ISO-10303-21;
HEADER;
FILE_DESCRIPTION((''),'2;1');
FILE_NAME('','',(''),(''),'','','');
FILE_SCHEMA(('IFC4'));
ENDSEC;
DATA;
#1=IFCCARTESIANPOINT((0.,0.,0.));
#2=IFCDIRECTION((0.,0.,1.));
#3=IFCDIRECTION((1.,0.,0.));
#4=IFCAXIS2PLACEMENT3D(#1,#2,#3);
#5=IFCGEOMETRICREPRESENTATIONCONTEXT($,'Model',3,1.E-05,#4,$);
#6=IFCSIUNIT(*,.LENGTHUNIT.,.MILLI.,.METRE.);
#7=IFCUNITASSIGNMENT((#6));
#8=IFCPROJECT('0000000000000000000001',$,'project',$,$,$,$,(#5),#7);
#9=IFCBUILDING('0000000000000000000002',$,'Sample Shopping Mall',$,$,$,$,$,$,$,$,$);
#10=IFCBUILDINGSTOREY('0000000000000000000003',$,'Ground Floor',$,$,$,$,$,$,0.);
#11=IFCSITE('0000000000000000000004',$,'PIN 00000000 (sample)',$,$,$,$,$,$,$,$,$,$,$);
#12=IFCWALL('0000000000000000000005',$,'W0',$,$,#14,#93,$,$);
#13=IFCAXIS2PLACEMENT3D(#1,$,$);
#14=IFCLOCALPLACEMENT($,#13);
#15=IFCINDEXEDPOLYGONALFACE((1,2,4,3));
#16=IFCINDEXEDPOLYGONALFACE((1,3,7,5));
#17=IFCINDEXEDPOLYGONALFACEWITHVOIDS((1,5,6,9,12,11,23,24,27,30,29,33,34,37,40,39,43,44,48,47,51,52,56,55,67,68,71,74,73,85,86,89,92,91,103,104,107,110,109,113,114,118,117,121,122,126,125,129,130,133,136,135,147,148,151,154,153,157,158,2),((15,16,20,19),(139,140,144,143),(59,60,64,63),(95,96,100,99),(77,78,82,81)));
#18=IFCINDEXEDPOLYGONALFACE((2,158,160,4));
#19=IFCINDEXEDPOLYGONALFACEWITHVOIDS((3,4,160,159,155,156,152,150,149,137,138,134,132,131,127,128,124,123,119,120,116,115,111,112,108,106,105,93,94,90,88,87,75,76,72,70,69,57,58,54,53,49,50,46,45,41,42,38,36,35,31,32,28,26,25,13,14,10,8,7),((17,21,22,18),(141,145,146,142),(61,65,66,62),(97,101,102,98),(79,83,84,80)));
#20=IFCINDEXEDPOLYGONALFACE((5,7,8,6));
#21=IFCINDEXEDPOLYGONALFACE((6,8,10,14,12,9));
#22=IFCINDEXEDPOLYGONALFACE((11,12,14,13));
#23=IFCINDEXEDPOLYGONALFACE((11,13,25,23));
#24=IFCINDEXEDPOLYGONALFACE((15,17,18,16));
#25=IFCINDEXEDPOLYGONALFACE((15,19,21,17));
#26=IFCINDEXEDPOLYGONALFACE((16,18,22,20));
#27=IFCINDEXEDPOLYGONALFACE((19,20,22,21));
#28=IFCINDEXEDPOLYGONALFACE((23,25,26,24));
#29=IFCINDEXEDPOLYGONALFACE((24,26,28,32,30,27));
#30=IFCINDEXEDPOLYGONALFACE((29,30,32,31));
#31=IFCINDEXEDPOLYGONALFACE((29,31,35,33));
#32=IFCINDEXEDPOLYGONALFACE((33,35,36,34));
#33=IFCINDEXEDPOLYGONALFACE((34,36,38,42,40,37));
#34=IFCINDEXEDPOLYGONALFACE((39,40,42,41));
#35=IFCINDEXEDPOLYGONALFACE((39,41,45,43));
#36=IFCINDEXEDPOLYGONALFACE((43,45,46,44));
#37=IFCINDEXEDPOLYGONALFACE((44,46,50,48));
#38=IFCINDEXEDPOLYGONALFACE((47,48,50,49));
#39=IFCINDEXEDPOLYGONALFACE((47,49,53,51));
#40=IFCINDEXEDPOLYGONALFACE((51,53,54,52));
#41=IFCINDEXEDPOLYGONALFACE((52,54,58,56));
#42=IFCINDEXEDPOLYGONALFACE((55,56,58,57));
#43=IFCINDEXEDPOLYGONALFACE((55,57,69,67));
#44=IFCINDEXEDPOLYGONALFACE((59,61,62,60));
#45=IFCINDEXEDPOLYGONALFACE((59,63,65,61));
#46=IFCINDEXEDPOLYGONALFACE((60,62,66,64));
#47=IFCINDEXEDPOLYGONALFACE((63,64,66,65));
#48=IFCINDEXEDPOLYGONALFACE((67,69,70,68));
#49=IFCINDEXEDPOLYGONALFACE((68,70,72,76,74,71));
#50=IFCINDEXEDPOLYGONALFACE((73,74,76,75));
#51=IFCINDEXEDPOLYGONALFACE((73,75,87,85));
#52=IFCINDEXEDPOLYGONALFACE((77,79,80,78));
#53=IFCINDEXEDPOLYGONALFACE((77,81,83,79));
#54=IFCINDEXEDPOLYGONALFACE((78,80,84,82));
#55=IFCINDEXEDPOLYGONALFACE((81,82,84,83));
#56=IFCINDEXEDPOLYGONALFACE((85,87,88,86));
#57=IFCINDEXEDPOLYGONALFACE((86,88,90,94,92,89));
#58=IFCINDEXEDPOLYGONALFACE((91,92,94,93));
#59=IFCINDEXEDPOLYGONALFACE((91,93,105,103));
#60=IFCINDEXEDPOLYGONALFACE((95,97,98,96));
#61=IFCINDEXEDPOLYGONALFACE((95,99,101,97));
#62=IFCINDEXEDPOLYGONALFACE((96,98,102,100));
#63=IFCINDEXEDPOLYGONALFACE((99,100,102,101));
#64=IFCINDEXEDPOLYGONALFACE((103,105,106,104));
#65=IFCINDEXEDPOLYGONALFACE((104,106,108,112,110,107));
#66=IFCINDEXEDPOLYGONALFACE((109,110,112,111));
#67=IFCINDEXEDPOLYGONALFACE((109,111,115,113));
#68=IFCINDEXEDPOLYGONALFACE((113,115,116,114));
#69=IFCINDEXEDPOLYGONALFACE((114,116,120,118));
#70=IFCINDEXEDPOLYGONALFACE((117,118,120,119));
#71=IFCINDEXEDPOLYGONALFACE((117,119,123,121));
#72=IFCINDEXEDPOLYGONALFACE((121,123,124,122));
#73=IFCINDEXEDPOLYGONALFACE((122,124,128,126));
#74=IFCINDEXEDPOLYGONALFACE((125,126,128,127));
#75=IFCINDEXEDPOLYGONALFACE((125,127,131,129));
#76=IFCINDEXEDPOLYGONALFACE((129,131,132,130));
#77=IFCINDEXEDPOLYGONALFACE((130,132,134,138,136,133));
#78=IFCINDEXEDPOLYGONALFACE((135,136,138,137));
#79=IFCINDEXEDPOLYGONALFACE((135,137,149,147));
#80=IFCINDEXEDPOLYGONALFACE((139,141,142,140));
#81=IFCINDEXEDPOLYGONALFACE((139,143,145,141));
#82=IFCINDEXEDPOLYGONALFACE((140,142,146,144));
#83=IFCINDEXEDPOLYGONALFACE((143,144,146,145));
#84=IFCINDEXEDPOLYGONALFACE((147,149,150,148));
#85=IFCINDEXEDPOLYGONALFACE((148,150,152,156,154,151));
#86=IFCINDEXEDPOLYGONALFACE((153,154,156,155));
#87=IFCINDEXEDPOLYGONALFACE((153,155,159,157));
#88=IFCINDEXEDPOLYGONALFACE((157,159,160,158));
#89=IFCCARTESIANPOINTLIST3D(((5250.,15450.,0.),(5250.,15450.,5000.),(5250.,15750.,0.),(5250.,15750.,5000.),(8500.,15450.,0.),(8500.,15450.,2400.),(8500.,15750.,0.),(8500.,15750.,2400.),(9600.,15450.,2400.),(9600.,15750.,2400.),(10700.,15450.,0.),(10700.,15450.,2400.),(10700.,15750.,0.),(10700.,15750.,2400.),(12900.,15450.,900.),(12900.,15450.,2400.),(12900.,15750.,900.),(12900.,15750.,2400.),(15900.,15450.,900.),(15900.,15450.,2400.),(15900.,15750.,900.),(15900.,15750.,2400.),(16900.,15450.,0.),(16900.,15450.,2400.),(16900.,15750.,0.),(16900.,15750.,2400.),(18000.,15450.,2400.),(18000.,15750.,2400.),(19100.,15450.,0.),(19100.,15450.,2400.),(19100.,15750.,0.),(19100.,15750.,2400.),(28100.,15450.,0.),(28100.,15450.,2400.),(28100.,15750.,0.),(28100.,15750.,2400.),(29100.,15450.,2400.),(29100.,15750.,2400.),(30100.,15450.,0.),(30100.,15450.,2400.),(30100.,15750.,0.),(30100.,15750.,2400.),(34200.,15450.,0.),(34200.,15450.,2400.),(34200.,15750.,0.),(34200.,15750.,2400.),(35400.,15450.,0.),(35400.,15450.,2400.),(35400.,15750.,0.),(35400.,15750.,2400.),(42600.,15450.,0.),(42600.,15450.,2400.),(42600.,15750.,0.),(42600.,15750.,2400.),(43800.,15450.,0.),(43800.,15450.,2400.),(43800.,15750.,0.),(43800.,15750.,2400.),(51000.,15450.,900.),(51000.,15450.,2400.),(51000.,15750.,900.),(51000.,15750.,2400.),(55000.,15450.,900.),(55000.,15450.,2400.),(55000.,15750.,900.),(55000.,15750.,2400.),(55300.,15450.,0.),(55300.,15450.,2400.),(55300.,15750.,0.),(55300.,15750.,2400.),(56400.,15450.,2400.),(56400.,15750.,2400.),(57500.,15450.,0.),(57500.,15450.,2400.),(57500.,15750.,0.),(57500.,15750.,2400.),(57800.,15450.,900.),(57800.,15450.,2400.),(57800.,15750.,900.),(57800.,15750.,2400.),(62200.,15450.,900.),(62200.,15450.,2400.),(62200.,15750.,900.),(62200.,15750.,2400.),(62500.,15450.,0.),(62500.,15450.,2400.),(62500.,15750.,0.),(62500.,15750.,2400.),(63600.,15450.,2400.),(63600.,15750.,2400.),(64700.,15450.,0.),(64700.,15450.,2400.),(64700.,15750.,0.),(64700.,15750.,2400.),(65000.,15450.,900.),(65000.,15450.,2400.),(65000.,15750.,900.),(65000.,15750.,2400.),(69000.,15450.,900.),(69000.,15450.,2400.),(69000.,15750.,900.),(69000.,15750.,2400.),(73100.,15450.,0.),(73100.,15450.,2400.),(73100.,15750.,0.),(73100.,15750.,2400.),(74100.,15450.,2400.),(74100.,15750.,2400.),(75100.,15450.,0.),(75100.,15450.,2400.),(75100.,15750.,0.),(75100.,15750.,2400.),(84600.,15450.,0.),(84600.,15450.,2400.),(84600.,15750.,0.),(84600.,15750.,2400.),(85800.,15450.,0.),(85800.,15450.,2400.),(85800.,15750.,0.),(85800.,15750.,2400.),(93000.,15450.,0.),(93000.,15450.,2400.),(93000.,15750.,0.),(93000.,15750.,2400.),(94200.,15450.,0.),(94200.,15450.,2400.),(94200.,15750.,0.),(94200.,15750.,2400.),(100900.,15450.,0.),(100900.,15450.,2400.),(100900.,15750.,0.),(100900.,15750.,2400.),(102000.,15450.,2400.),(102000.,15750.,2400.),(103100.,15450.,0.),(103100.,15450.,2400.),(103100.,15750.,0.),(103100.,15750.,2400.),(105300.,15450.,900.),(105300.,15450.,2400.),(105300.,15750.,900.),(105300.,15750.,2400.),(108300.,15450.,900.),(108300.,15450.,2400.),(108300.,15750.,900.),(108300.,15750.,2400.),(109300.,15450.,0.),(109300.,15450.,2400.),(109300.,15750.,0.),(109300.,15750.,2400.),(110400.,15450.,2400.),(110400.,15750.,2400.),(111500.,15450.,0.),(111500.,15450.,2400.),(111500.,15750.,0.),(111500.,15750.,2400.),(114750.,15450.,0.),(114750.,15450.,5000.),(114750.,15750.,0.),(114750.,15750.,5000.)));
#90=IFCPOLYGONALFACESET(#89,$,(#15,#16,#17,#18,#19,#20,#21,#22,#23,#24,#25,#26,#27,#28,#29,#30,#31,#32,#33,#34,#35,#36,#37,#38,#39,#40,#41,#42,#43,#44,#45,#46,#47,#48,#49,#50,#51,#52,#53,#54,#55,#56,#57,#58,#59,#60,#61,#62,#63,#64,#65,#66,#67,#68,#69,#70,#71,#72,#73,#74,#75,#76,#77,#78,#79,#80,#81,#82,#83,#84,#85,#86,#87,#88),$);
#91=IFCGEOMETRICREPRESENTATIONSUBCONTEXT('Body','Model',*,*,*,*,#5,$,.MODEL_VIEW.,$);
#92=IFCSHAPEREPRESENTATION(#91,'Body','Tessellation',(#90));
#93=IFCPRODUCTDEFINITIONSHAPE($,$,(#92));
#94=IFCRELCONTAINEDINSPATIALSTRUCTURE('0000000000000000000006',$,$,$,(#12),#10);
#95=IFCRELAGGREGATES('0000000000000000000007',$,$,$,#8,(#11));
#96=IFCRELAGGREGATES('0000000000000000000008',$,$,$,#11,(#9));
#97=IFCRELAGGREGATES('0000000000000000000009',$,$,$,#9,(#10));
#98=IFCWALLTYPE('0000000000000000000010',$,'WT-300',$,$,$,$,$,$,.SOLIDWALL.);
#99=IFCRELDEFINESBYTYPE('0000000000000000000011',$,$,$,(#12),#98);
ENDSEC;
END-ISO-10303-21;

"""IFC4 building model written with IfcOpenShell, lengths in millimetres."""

from ifc_helpers import new_model, si_unit, frame, origin_with_axes, place, context, subcontext, project, spatial, indexed_curve, outline, extrude, type_object, element, save


model = new_model("IFC4")

# Units and contexts
model_context = context("Model", 3, precision=1e-05, world=origin_with_axes())
body_context = subcontext(model_context, "Body", "Model", "MODEL_VIEW")
ifc_project = project(units=[si_unit("LENGTHUNIT", "METRE", prefix="MILLI")], contexts=[model_context])

# Site, building, storey
site = spatial("IfcSite", under=ifc_project, Name="PIN 00000000 (sample)")
building = spatial("IfcBuilding", under=site, Name="Sample Shopping Mall")
storey = spatial("IfcBuildingStorey", under=building, Name="Ground Floor", Elevation=0.0)

# Wall, openings
wall_type = type_object("IfcWallType", Name="WT-300", PredefinedType="SOLIDWALL")
wall_placement = place(None, frame((5250.0, 15450.0, 0.0), z_axis=(0.0, 0.0, 1.0), x_axis=(1.0, 0.0, 0.0)))
wall = element("IfcWall", 1, at=wall_placement, inside=storey, type_object=wall_type, Name="W0", context=body_context, shape_type="SweptSolid", body=[
    extrude(outline(indexed_curve([(0.0, 0.0), (0.0, 300.0), (109500.0, 300.0), (109500.0, 0.0), (0.0, 0.0)], self_intersect=False)), origin_with_axes(), (0.0, 0.0, 1.0), 5000.0),
])
opening_1_placement = place(wall_placement, frame((50050.0, -100.0, 0.0), z_axis=(0.0, 0.0, 1.0), x_axis=(1.0, 0.0, 0.0)))
element("IfcOpeningElement", 2, at=opening_1_placement, cuts=wall, context=body_context, shape_type="SweptSolid", body=[
    extrude(outline(indexed_curve([(0.0, 0.0), (0.0, 500.0), (1100.0, 500.0), (1100.0, 0.0), (0.0, 0.0)], self_intersect=False)), origin_with_axes(), (0.0, 0.0, 1.0), 2400.0),
])
opening_2_placement = place(wall_placement, frame((51150.0, -100.0, 0.0), z_axis=(0.0, 0.0, 1.0), x_axis=(1.0, 0.0, 0.0)))
element("IfcOpeningElement", 3, at=opening_2_placement, cuts=wall, context=body_context, shape_type="SweptSolid", body=[
    extrude(outline(indexed_curve([(0.0, 0.0), (0.0, 500.0), (1100.0, 500.0), (1100.0, 0.0), (0.0, 0.0)], self_intersect=False)), origin_with_axes(), (0.0, 0.0, 1.0), 2400.0),
])
opening_3_placement = place(wall_placement, frame((57250.0, -100.0, 0.0), z_axis=(0.0, 0.0, 1.0), x_axis=(1.0, 0.0, 0.0)))
element("IfcOpeningElement", 4, at=opening_3_placement, cuts=wall, context=body_context, shape_type="SweptSolid", body=[
    extrude(outline(indexed_curve([(0.0, 0.0), (0.0, 500.0), (1100.0, 500.0), (1100.0, 0.0), (0.0, 0.0)], self_intersect=False)), origin_with_axes(), (0.0, 0.0, 1.0), 2400.0),
])
opening_4_placement = place(wall_placement, frame((58350.0, -100.0, 0.0), z_axis=(0.0, 0.0, 1.0), x_axis=(1.0, 0.0, 0.0)))
element("IfcOpeningElement", 5, at=opening_4_placement, cuts=wall, context=body_context, shape_type="SweptSolid", body=[
    extrude(outline(indexed_curve([(0.0, 0.0), (0.0, 500.0), (1100.0, 500.0), (1100.0, 0.0), (0.0, 0.0)], self_intersect=False)), origin_with_axes(), (0.0, 0.0, 1.0), 2400.0),
])
opening_5_placement = place(wall_placement, frame((3250.0, -100.0, 0.0), z_axis=(0.0, 0.0, 1.0), x_axis=(1.0, 0.0, 0.0)))
element("IfcOpeningElement", 6, at=opening_5_placement, cuts=wall, context=body_context, shape_type="SweptSolid", body=[
    extrude(outline(indexed_curve([(0.0, 0.0), (0.0, 500.0), (1100.0, 500.0), (1100.0, 0.0), (0.0, 0.0)], self_intersect=False)), origin_with_axes(), (0.0, 0.0, 1.0), 2400.0),
])
opening_6_placement = place(wall_placement, frame((4350.0, -100.0, 0.0), z_axis=(0.0, 0.0, 1.0), x_axis=(1.0, 0.0, 0.0)))
element("IfcOpeningElement", 7, at=opening_6_placement, cuts=wall, context=body_context, shape_type="SweptSolid", body=[
    extrude(outline(indexed_curve([(0.0, 0.0), (0.0, 500.0), (1100.0, 500.0), (1100.0, 0.0), (0.0, 0.0)], self_intersect=False)), origin_with_axes(), (0.0, 0.0, 1.0), 2400.0),
])
opening_7_placement = place(wall_placement, frame((11650.0, -100.0, 0.0), z_axis=(0.0, 0.0, 1.0), x_axis=(1.0, 0.0, 0.0)))
element("IfcOpeningElement", 8, at=opening_7_placement, cuts=wall, context=body_context, shape_type="SweptSolid", body=[
    extrude(outline(indexed_curve([(0.0, 0.0), (0.0, 500.0), (1100.0, 500.0), (1100.0, 0.0), (0.0, 0.0)], self_intersect=False)), origin_with_axes(), (0.0, 0.0, 1.0), 2400.0),
])
opening_8_placement = place(wall_placement, frame((12750.0, -100.0, 0.0), z_axis=(0.0, 0.0, 1.0), x_axis=(1.0, 0.0, 0.0)))
element("IfcOpeningElement", 9, at=opening_8_placement, cuts=wall, context=body_context, shape_type="SweptSolid", body=[
    extrude(outline(indexed_curve([(0.0, 0.0), (0.0, 500.0), (1100.0, 500.0), (1100.0, 0.0), (0.0, 0.0)], self_intersect=False)), origin_with_axes(), (0.0, 0.0, 1.0), 2400.0),
])
opening_9_placement = place(wall_placement, frame((95650.0, -100.0, 0.0), z_axis=(0.0, 0.0, 1.0), x_axis=(1.0, 0.0, 0.0)))
element("IfcOpeningElement", 10, at=opening_9_placement, cuts=wall, context=body_context, shape_type="SweptSolid", body=[
    extrude(outline(indexed_curve([(0.0, 0.0), (0.0, 500.0), (1100.0, 500.0), (1100.0, 0.0), (0.0, 0.0)], self_intersect=False)), origin_with_axes(), (0.0, 0.0, 1.0), 2400.0),
])
opening_10_placement = place(wall_placement, frame((96750.0, -100.0, 0.0), z_axis=(0.0, 0.0, 1.0), x_axis=(1.0, 0.0, 0.0)))
element("IfcOpeningElement", 11, at=opening_10_placement, cuts=wall, context=body_context, shape_type="SweptSolid", body=[
    extrude(outline(indexed_curve([(0.0, 0.0), (0.0, 500.0), (1100.0, 500.0), (1100.0, 0.0), (0.0, 0.0)], self_intersect=False)), origin_with_axes(), (0.0, 0.0, 1.0), 2400.0),
])
opening_11_placement = place(wall_placement, frame((104050.0, -100.0, 0.0), z_axis=(0.0, 0.0, 1.0), x_axis=(1.0, 0.0, 0.0)))
element("IfcOpeningElement", 12, at=opening_11_placement, cuts=wall, context=body_context, shape_type="SweptSolid", body=[
    extrude(outline(indexed_curve([(0.0, 0.0), (0.0, 500.0), (1100.0, 500.0), (1100.0, 0.0), (0.0, 0.0)], self_intersect=False)), origin_with_axes(), (0.0, 0.0, 1.0), 2400.0),
])
opening_12_placement = place(wall_placement, frame((105150.0, -100.0, 0.0), z_axis=(0.0, 0.0, 1.0), x_axis=(1.0, 0.0, 0.0)))
element("IfcOpeningElement", 13, at=opening_12_placement, cuts=wall, context=body_context, shape_type="SweptSolid", body=[
    extrude(outline(indexed_curve([(0.0, 0.0), (0.0, 500.0), (1100.0, 500.0), (1100.0, 0.0), (0.0, 0.0)], self_intersect=False)), origin_with_axes(), (0.0, 0.0, 1.0), 2400.0),
])
opening_13_placement = place(wall_placement, frame((28950.0, -100.0, 0.0), z_axis=(0.0, 0.0, 1.0), x_axis=(1.0, 0.0, 0.0)))
element("IfcOpeningElement", 14, at=opening_13_placement, cuts=wall, context=body_context, shape_type="SweptSolid", body=[
    extrude(outline(indexed_curve([(0.0, 0.0), (0.0, 500.0), (1200.0, 500.0), (1200.0, 0.0), (0.0, 0.0)], self_intersect=False)), origin_with_axes(), (0.0, 0.0, 1.0), 2400.0),
])
opening_14_placement = place(wall_placement, frame((37350.0, -100.0, 0.0), z_axis=(0.0, 0.0, 1.0), x_axis=(1.0, 0.0, 0.0)))
element("IfcOpeningElement", 15, at=opening_14_placement, cuts=wall, context=body_context, shape_type="SweptSolid", body=[
    extrude(outline(indexed_curve([(0.0, 0.0), (0.0, 500.0), (1200.0, 500.0), (1200.0, 0.0), (0.0, 0.0)], self_intersect=False)), origin_with_axes(), (0.0, 0.0, 1.0), 2400.0),
])
opening_15_placement = place(wall_placement, frame((79350.0, -100.0, 0.0), z_axis=(0.0, 0.0, 1.0), x_axis=(1.0, 0.0, 0.0)))
element("IfcOpeningElement", 16, at=opening_15_placement, cuts=wall, context=body_context, shape_type="SweptSolid", body=[
    extrude(outline(indexed_curve([(0.0, 0.0), (0.0, 500.0), (1200.0, 500.0), (1200.0, 0.0), (0.0, 0.0)], self_intersect=False)), origin_with_axes(), (0.0, 0.0, 1.0), 2400.0),
])
opening_16_placement = place(wall_placement, frame((87750.0, -100.0, 0.0), z_axis=(0.0, 0.0, 1.0), x_axis=(1.0, 0.0, 0.0)))
element("IfcOpeningElement", 17, at=opening_16_placement, cuts=wall, context=body_context, shape_type="SweptSolid", body=[
    extrude(outline(indexed_curve([(0.0, 0.0), (0.0, 500.0), (1200.0, 500.0), (1200.0, 0.0), (0.0, 0.0)], self_intersect=False)), origin_with_axes(), (0.0, 0.0, 1.0), 2400.0),
])
opening_17_placement = place(wall_placement, frame((22850.0, -100.0, 0.0), z_axis=(0.0, 0.0, 1.0), x_axis=(1.0, 0.0, 0.0)))
element("IfcOpeningElement", 18, at=opening_17_placement, cuts=wall, context=body_context, shape_type="SweptSolid", body=[
    extrude(outline(indexed_curve([(0.0, 0.0), (0.0, 500.0), (1000.0, 500.0), (1000.0, 0.0), (0.0, 0.0)], self_intersect=False)), origin_with_axes(), (0.0, 0.0, 1.0), 2400.0),
])
opening_18_placement = place(wall_placement, frame((23850.0, -100.0, 0.0), z_axis=(0.0, 0.0, 1.0), x_axis=(1.0, 0.0, 0.0)))
element("IfcOpeningElement", 19, at=opening_18_placement, cuts=wall, context=body_context, shape_type="SweptSolid", body=[
    extrude(outline(indexed_curve([(0.0, 0.0), (0.0, 500.0), (1000.0, 500.0), (1000.0, 0.0), (0.0, 0.0)], self_intersect=False)), origin_with_axes(), (0.0, 0.0, 1.0), 2400.0),
])
opening_19_placement = place(wall_placement, frame((67850.0, -100.0, 0.0), z_axis=(0.0, 0.0, 1.0), x_axis=(1.0, 0.0, 0.0)))
element("IfcOpeningElement", 20, at=opening_19_placement, cuts=wall, context=body_context, shape_type="SweptSolid", body=[
    extrude(outline(indexed_curve([(0.0, 0.0), (0.0, 500.0), (1000.0, 500.0), (1000.0, 0.0), (0.0, 0.0)], self_intersect=False)), origin_with_axes(), (0.0, 0.0, 1.0), 2400.0),
])
opening_20_placement = place(wall_placement, frame((68850.0, -100.0, 0.0), z_axis=(0.0, 0.0, 1.0), x_axis=(1.0, 0.0, 0.0)))
element("IfcOpeningElement", 21, at=opening_20_placement, cuts=wall, context=body_context, shape_type="SweptSolid", body=[
    extrude(outline(indexed_curve([(0.0, 0.0), (0.0, 500.0), (1000.0, 500.0), (1000.0, 0.0), (0.0, 0.0)], self_intersect=False)), origin_with_axes(), (0.0, 0.0, 1.0), 2400.0),
])
opening_21_placement = place(wall_placement, frame((45750.0, -100.0, 900.0), z_axis=(0.0, 0.0, 1.0), x_axis=(1.0, 0.0, 0.0)))
element("IfcOpeningElement", 22, at=opening_21_placement, cuts=wall, context=body_context, shape_type="SweptSolid", body=[
    extrude(outline(indexed_curve([(0.0, 0.0), (0.0, 500.0), (4000.0, 500.0), (4000.0, 0.0), (0.0, 0.0)], self_intersect=False)), origin_with_axes(), (0.0, 0.0, 1.0), 1500.0),
])
opening_22_placement = place(wall_placement, frame((52550.0, -100.0, 900.0), z_axis=(0.0, 0.0, 1.0), x_axis=(1.0, 0.0, 0.0)))
element("IfcOpeningElement", 23, at=opening_22_placement, cuts=wall, context=body_context, shape_type="SweptSolid", body=[
    extrude(outline(indexed_curve([(0.0, 0.0), (0.0, 500.0), (4400.0, 500.0), (4400.0, 0.0), (0.0, 0.0)], self_intersect=False)), origin_with_axes(), (0.0, 0.0, 1.0), 1500.0),
])
opening_23_placement = place(wall_placement, frame((59750.0, -100.0, 900.0), z_axis=(0.0, 0.0, 1.0), x_axis=(1.0, 0.0, 0.0)))
element("IfcOpeningElement", 24, at=opening_23_placement, cuts=wall, context=body_context, shape_type="SweptSolid", body=[
    extrude(outline(indexed_curve([(0.0, 0.0), (0.0, 500.0), (4000.0, 500.0), (4000.0, 0.0), (0.0, 0.0)], self_intersect=False)), origin_with_axes(), (0.0, 0.0, 1.0), 1500.0),
])
opening_24_placement = place(wall_placement, frame((7650.0, -100.0, 900.0), z_axis=(0.0, 0.0, 1.0), x_axis=(1.0, 0.0, 0.0)))
element("IfcOpeningElement", 25, at=opening_24_placement, cuts=wall, context=body_context, shape_type="SweptSolid", body=[
    extrude(outline(indexed_curve([(0.0, 0.0), (0.0, 500.0), (3000.0, 500.0), (3000.0, 0.0), (0.0, 0.0)], self_intersect=False)), origin_with_axes(), (0.0, 0.0, 1.0), 1500.0),
])
opening_25_placement = place(wall_placement, frame((100050.0, -100.0, 900.0), z_axis=(0.0, 0.0, 1.0), x_axis=(1.0, 0.0, 0.0)))
element("IfcOpeningElement", 26, at=opening_25_placement, cuts=wall, context=body_context, shape_type="SweptSolid", body=[
    extrude(outline(indexed_curve([(0.0, 0.0), (0.0, 500.0), (3000.0, 500.0), (3000.0, 0.0), (0.0, 0.0)], self_intersect=False)), origin_with_axes(), (0.0, 0.0, 1.0), 1500.0),
])

save(model, "model.ifc")
